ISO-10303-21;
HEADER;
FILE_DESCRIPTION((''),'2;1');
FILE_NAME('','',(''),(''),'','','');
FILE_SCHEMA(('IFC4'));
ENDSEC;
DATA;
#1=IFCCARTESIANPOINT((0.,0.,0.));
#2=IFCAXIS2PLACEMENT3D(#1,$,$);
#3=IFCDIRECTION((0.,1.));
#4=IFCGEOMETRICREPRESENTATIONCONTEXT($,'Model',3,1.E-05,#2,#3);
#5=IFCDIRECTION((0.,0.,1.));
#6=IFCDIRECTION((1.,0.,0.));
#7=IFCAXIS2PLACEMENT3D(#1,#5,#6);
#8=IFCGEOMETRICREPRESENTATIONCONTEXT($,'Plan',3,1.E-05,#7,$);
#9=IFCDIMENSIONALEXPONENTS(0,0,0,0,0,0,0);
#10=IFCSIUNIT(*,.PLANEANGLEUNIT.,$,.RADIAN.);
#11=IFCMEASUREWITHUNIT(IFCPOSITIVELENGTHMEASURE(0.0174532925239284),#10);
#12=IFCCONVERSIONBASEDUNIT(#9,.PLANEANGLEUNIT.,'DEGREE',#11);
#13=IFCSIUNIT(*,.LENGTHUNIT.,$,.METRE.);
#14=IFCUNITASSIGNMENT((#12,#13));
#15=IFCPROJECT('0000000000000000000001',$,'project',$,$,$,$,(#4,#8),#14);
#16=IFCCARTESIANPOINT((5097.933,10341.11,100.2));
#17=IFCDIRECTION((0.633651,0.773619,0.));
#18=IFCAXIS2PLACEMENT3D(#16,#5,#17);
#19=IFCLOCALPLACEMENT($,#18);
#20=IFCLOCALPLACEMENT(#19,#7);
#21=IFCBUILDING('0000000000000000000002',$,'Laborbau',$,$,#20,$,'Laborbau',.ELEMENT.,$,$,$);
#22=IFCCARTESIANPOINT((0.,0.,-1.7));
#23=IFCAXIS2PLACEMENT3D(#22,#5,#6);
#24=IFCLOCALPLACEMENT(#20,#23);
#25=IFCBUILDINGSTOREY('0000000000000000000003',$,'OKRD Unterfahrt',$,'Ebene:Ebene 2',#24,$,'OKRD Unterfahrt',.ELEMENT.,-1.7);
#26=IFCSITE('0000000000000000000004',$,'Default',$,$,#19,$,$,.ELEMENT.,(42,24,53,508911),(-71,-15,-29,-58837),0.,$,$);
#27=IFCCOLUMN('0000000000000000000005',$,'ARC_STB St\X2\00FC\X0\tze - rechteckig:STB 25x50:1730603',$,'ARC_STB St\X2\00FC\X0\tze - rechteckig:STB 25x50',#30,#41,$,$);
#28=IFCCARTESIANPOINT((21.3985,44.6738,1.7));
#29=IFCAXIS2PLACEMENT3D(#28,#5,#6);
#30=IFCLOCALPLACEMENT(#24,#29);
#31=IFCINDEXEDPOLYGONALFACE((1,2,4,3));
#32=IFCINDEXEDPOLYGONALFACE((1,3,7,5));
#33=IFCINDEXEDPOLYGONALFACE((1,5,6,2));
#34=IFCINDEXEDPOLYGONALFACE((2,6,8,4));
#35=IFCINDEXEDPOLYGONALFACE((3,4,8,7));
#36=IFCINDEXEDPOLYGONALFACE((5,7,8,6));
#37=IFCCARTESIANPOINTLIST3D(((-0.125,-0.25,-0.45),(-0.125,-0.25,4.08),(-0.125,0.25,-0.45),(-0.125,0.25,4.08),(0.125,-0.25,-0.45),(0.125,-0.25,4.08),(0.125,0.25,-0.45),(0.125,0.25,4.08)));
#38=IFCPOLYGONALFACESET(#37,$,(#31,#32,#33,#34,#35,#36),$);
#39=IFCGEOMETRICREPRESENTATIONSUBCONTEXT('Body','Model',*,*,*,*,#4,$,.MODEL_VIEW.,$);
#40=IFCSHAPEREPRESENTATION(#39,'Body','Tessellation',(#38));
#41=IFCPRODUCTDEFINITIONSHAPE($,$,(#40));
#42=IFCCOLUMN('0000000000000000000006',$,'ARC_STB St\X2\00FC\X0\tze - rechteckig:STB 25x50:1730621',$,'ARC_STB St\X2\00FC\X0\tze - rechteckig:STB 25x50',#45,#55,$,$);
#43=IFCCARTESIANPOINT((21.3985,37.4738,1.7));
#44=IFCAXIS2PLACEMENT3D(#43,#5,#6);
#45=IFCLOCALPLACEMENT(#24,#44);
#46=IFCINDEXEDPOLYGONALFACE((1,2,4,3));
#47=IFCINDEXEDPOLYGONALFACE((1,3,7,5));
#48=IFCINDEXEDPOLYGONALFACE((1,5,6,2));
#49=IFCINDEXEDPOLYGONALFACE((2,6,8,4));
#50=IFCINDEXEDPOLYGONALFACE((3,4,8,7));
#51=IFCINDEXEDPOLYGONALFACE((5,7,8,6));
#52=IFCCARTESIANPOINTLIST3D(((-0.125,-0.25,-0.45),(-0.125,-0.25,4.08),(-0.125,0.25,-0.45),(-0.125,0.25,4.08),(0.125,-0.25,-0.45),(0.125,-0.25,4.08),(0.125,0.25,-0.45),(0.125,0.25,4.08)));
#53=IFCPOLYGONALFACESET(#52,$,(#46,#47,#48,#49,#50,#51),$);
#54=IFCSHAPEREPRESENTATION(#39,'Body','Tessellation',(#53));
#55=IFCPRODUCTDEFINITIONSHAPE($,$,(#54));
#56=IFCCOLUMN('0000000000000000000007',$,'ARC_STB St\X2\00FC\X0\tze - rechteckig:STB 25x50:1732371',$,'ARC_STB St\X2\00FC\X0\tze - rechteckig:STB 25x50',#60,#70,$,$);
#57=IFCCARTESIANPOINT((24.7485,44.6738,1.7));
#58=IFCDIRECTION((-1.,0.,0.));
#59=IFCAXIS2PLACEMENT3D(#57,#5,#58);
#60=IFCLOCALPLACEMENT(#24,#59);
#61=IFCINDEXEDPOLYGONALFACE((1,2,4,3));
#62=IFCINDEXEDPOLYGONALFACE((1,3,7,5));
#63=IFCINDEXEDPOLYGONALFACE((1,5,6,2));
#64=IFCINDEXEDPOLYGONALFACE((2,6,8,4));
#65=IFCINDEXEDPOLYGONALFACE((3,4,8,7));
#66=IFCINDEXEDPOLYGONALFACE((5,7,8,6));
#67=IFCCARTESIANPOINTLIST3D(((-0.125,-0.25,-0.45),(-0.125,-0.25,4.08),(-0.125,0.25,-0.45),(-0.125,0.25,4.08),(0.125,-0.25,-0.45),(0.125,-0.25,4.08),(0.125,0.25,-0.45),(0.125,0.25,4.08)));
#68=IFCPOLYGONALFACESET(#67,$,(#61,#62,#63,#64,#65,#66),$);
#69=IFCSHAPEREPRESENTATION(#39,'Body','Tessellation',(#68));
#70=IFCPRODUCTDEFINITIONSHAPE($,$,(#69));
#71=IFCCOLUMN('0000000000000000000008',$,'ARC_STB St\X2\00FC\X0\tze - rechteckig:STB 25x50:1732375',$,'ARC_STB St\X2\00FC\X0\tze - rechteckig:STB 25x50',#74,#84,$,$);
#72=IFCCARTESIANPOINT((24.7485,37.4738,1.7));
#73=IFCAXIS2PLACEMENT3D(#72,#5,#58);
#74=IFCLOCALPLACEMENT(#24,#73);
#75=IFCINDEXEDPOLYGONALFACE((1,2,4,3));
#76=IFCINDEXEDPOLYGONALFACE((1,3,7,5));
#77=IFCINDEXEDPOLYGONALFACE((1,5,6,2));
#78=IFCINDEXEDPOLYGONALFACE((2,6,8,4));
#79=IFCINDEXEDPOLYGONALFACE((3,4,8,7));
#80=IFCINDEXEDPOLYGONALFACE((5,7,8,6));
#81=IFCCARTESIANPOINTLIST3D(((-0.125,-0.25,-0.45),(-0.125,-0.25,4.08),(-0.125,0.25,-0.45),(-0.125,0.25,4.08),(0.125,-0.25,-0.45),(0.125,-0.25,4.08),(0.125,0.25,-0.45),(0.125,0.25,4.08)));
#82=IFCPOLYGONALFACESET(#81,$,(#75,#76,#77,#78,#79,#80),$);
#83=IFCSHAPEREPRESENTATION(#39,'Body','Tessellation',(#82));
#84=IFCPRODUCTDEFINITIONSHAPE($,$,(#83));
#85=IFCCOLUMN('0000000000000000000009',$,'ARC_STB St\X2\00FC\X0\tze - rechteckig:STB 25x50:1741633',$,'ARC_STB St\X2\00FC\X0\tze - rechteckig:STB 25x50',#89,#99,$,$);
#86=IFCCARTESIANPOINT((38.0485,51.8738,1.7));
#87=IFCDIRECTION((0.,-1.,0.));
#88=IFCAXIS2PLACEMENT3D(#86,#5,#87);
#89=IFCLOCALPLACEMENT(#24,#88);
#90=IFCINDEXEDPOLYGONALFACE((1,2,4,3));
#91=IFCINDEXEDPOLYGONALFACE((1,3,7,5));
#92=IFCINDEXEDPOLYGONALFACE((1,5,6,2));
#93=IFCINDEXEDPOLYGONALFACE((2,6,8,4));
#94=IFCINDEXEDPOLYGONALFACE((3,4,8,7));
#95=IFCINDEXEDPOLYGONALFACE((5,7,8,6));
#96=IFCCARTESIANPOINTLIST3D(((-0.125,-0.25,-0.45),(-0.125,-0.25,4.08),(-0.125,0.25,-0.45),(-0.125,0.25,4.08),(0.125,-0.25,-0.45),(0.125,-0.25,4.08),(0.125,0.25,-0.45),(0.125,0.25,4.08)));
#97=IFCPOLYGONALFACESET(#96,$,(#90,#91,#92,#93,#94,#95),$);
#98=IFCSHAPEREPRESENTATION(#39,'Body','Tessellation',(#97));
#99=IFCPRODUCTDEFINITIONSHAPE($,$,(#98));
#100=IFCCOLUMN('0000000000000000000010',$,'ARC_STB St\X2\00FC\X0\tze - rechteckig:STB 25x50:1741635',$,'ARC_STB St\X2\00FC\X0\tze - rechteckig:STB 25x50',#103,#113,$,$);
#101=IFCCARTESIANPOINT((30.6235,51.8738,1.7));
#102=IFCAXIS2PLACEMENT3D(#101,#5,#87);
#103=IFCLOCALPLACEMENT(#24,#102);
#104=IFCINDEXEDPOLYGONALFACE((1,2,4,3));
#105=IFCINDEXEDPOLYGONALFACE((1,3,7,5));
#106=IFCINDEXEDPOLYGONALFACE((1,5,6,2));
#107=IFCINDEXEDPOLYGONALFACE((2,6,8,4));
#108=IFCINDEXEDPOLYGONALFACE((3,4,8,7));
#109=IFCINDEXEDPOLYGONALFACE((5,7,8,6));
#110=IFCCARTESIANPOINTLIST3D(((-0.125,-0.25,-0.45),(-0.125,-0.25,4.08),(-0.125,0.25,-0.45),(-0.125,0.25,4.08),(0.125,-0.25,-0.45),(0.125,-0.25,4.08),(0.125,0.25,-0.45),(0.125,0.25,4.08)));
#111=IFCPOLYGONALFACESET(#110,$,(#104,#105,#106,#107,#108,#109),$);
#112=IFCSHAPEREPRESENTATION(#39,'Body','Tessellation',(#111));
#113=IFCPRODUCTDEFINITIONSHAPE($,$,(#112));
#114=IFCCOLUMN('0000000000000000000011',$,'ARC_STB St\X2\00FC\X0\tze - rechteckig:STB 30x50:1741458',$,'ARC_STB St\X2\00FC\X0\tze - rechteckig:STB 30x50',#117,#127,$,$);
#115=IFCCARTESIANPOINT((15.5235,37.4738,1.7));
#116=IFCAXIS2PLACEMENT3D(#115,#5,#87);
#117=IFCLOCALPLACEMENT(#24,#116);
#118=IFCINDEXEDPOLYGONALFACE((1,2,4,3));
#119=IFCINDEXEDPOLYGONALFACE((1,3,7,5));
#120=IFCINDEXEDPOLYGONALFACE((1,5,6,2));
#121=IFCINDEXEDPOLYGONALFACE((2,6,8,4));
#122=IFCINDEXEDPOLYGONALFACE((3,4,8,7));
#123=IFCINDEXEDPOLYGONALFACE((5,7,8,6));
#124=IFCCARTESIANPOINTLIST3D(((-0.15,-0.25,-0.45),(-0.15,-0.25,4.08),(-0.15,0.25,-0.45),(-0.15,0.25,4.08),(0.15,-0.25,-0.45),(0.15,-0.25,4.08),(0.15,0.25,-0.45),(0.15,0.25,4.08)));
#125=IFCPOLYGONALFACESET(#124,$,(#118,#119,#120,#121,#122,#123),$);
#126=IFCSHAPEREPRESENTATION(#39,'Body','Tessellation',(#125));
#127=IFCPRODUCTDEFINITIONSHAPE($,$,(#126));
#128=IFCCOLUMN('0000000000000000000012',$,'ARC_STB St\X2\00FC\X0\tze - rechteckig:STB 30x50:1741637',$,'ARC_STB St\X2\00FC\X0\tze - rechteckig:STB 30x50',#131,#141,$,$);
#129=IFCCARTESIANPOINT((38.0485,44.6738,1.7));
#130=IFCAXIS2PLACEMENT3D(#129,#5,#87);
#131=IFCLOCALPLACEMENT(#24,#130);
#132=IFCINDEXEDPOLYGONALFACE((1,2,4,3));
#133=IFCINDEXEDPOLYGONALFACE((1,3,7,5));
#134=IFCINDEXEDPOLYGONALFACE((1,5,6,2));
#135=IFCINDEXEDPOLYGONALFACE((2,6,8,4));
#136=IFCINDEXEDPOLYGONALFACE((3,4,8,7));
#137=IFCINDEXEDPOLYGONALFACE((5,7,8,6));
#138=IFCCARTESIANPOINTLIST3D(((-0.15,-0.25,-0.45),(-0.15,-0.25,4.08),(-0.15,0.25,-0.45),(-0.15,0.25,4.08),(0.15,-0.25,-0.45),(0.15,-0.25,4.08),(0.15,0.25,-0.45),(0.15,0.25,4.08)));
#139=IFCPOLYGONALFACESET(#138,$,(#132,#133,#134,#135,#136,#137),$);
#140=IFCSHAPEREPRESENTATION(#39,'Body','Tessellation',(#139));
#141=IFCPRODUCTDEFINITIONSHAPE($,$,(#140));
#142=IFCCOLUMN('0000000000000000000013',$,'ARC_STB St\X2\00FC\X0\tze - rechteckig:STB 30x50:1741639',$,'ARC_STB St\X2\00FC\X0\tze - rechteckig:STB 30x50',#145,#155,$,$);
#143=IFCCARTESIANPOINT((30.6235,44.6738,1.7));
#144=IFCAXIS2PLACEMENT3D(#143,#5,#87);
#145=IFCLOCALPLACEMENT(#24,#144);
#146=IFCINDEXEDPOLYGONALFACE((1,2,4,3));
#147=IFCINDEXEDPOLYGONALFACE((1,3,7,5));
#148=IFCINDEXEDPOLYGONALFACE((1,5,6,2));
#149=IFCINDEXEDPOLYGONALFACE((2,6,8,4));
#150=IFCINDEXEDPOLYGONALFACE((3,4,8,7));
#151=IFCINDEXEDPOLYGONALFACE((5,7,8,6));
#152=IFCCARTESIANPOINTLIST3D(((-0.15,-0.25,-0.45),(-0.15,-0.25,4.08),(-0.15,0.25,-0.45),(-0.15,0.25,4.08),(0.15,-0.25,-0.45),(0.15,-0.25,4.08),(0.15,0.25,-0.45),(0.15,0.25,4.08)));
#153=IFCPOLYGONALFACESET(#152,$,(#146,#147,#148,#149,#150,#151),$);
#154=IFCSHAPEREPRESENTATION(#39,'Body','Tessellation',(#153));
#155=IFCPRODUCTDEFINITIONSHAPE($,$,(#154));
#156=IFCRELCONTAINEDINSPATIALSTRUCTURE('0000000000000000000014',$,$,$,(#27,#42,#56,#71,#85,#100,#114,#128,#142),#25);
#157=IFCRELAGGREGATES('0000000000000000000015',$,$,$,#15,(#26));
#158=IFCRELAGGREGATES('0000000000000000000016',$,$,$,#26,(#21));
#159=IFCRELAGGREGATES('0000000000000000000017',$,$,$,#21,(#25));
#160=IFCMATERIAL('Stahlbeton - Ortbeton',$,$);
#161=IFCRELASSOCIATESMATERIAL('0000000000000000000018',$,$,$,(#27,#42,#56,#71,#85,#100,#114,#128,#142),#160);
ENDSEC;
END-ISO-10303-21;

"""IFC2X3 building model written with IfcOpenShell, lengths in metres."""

from ifc_helpers import new_model, entity, si_unit, converted_unit, direction, frame, origin, origin_with_axes, origin_2d_with_axis, place, context, subcontext, project, spatial, rectangle, extrude, source, transform, mapped, material, element, save


model = new_model("IFC2X3")

# Units and contexts
model_context = context("Model", 3, precision=1e-05, world=origin(), true_north=direction((0.0, 1.0)))
plan_context = context("Plan", 3, precision=1e-05, world=origin_with_axes())
body_context = subcontext(model_context, "Body", "Model", "MODEL_VIEW")
ifc_project = project(units=[converted_unit("PLANEANGLEUNIT", "DEGREE", entity("IfcPositiveLengthMeasure", 0.0174532925239284), si_unit("PLANEANGLEUNIT", "RADIAN"), dimensions=[0, 0, 0, 0, 0, 0, 0]), si_unit("LENGTHUNIT", "METRE")], contexts=[model_context, plan_context])

# Site, building, storey
site_placement = place(None, frame((5097.933, 10341.11, 100.2), z_axis=(0.0, 0.0, 1.0), x_axis=(0.633651, 0.773619, 0.0)))
site = spatial("IfcSite", under=ifc_project, at=site_placement, Name="Default", CompositionType="ELEMENT", RefLatitude=(42, 24, 53, 508911), RefLongitude=(-71, -15, -29, -58837), RefElevation=0.0)
building_placement = place(site_placement, origin_with_axes())
building = spatial("IfcBuilding", under=site, at=building_placement, Name="Laborbau", LongName="Laborbau", CompositionType="ELEMENT")
storey_placement = place(building_placement, frame((0.0, 0.0, -1.7), z_axis=(0.0, 0.0, 1.0), x_axis=(1.0, 0.0, 0.0)))
storey = spatial("IfcBuildingStorey", under=building, at=storey_placement, Name="OKRD Unterfahrt", ObjectType="Ebene:Ebene 2", LongName="OKRD Unterfahrt", CompositionType="ELEMENT", Elevation=-1.7)

# Columns
ifc_material_1 = material(Name="Stahlbeton - Ortbeton")
shared_shape_1 = source(origin(), body_context, "Body", "SweptSolid", [
    extrude(rectangle(XDim=0.5, YDim=0.25, at=origin_2d_with_axis()), frame((0.0, 0.0, -0.45), z_axis=(0.0, 0.0, 1.0), x_axis=(0.0, -1.0, 0.0)), (0.0, 0.0, 1.0), 4.53),
])
for number, where, z_axis, x_axis, name in (
    (1, (21.3985, 44.6738, 1.7), (0.0, 0.0, 1.0), (1.0, 0.0, 0.0), "ARC_STB Stütze - rechteckig:STB 25x50:1730603"),
    (2, (21.3985, 37.4738, 1.7), (0.0, 0.0, 1.0), (1.0, 0.0, 0.0), "ARC_STB Stütze - rechteckig:STB 25x50:1730621"),
    (3, (24.7485, 44.6738, 1.7), (0.0, 0.0, 1.0), (-1.0, 0.0, 0.0), "ARC_STB Stütze - rechteckig:STB 25x50:1732371"),
    (4, (24.7485, 37.4738, 1.7), (0.0, 0.0, 1.0), (-1.0, 0.0, 0.0), "ARC_STB Stütze - rechteckig:STB 25x50:1732375"),
    (5, (38.0485, 51.8738, 1.7), (0.0, 0.0, 1.0), (0.0, -1.0, 0.0), "ARC_STB Stütze - rechteckig:STB 25x50:1741633"),
    (6, (30.6235, 51.8738, 1.7), (0.0, 0.0, 1.0), (0.0, -1.0, 0.0), "ARC_STB Stütze - rechteckig:STB 25x50:1741635"),
):
    element("IfcColumn", number, at=place(storey_placement, frame(where, z_axis=z_axis, x_axis=x_axis)), inside=storey, material=ifc_material_1, Name=name, ObjectType="ARC_STB Stütze - rechteckig:STB 25x50", context=body_context, shape_type="MappedRepresentation", body=[
        mapped(shared_shape_1, transform((0.0, 0.0, 0.0), scale=1.0)),
    ])
shared_shape_2 = source(origin(), body_context, "Body", "SweptSolid", [
    extrude(rectangle(XDim=0.5, YDim=0.3, at=origin_2d_with_axis()), frame((0.0, 0.0, -0.45), z_axis=(0.0, 0.0, 1.0), x_axis=(0.0, -1.0, 0.0)), (0.0, 0.0, 1.0), 4.53),
])
for number, where, z_axis, x_axis, name in (
    (7, (15.5235, 37.4738, 1.7), (0.0, 0.0, 1.0), (0.0, -1.0, 0.0), "ARC_STB Stütze - rechteckig:STB 30x50:1741458"),
    (8, (38.0485, 44.6738, 1.7), (0.0, 0.0, 1.0), (0.0, -1.0, 0.0), "ARC_STB Stütze - rechteckig:STB 30x50:1741637"),
    (9, (30.6235, 44.6738, 1.7), (0.0, 0.0, 1.0), (0.0, -1.0, 0.0), "ARC_STB Stütze - rechteckig:STB 30x50:1741639"),
):
    element("IfcColumn", number, at=place(storey_placement, frame(where, z_axis=z_axis, x_axis=x_axis)), inside=storey, material=ifc_material_1, Name=name, ObjectType="ARC_STB Stütze - rechteckig:STB 30x50", context=body_context, shape_type="MappedRepresentation", body=[
        mapped(shared_shape_2, transform((0.0, 0.0, 0.0), scale=1.0)),
    ])

save(model, "model.ifc")
